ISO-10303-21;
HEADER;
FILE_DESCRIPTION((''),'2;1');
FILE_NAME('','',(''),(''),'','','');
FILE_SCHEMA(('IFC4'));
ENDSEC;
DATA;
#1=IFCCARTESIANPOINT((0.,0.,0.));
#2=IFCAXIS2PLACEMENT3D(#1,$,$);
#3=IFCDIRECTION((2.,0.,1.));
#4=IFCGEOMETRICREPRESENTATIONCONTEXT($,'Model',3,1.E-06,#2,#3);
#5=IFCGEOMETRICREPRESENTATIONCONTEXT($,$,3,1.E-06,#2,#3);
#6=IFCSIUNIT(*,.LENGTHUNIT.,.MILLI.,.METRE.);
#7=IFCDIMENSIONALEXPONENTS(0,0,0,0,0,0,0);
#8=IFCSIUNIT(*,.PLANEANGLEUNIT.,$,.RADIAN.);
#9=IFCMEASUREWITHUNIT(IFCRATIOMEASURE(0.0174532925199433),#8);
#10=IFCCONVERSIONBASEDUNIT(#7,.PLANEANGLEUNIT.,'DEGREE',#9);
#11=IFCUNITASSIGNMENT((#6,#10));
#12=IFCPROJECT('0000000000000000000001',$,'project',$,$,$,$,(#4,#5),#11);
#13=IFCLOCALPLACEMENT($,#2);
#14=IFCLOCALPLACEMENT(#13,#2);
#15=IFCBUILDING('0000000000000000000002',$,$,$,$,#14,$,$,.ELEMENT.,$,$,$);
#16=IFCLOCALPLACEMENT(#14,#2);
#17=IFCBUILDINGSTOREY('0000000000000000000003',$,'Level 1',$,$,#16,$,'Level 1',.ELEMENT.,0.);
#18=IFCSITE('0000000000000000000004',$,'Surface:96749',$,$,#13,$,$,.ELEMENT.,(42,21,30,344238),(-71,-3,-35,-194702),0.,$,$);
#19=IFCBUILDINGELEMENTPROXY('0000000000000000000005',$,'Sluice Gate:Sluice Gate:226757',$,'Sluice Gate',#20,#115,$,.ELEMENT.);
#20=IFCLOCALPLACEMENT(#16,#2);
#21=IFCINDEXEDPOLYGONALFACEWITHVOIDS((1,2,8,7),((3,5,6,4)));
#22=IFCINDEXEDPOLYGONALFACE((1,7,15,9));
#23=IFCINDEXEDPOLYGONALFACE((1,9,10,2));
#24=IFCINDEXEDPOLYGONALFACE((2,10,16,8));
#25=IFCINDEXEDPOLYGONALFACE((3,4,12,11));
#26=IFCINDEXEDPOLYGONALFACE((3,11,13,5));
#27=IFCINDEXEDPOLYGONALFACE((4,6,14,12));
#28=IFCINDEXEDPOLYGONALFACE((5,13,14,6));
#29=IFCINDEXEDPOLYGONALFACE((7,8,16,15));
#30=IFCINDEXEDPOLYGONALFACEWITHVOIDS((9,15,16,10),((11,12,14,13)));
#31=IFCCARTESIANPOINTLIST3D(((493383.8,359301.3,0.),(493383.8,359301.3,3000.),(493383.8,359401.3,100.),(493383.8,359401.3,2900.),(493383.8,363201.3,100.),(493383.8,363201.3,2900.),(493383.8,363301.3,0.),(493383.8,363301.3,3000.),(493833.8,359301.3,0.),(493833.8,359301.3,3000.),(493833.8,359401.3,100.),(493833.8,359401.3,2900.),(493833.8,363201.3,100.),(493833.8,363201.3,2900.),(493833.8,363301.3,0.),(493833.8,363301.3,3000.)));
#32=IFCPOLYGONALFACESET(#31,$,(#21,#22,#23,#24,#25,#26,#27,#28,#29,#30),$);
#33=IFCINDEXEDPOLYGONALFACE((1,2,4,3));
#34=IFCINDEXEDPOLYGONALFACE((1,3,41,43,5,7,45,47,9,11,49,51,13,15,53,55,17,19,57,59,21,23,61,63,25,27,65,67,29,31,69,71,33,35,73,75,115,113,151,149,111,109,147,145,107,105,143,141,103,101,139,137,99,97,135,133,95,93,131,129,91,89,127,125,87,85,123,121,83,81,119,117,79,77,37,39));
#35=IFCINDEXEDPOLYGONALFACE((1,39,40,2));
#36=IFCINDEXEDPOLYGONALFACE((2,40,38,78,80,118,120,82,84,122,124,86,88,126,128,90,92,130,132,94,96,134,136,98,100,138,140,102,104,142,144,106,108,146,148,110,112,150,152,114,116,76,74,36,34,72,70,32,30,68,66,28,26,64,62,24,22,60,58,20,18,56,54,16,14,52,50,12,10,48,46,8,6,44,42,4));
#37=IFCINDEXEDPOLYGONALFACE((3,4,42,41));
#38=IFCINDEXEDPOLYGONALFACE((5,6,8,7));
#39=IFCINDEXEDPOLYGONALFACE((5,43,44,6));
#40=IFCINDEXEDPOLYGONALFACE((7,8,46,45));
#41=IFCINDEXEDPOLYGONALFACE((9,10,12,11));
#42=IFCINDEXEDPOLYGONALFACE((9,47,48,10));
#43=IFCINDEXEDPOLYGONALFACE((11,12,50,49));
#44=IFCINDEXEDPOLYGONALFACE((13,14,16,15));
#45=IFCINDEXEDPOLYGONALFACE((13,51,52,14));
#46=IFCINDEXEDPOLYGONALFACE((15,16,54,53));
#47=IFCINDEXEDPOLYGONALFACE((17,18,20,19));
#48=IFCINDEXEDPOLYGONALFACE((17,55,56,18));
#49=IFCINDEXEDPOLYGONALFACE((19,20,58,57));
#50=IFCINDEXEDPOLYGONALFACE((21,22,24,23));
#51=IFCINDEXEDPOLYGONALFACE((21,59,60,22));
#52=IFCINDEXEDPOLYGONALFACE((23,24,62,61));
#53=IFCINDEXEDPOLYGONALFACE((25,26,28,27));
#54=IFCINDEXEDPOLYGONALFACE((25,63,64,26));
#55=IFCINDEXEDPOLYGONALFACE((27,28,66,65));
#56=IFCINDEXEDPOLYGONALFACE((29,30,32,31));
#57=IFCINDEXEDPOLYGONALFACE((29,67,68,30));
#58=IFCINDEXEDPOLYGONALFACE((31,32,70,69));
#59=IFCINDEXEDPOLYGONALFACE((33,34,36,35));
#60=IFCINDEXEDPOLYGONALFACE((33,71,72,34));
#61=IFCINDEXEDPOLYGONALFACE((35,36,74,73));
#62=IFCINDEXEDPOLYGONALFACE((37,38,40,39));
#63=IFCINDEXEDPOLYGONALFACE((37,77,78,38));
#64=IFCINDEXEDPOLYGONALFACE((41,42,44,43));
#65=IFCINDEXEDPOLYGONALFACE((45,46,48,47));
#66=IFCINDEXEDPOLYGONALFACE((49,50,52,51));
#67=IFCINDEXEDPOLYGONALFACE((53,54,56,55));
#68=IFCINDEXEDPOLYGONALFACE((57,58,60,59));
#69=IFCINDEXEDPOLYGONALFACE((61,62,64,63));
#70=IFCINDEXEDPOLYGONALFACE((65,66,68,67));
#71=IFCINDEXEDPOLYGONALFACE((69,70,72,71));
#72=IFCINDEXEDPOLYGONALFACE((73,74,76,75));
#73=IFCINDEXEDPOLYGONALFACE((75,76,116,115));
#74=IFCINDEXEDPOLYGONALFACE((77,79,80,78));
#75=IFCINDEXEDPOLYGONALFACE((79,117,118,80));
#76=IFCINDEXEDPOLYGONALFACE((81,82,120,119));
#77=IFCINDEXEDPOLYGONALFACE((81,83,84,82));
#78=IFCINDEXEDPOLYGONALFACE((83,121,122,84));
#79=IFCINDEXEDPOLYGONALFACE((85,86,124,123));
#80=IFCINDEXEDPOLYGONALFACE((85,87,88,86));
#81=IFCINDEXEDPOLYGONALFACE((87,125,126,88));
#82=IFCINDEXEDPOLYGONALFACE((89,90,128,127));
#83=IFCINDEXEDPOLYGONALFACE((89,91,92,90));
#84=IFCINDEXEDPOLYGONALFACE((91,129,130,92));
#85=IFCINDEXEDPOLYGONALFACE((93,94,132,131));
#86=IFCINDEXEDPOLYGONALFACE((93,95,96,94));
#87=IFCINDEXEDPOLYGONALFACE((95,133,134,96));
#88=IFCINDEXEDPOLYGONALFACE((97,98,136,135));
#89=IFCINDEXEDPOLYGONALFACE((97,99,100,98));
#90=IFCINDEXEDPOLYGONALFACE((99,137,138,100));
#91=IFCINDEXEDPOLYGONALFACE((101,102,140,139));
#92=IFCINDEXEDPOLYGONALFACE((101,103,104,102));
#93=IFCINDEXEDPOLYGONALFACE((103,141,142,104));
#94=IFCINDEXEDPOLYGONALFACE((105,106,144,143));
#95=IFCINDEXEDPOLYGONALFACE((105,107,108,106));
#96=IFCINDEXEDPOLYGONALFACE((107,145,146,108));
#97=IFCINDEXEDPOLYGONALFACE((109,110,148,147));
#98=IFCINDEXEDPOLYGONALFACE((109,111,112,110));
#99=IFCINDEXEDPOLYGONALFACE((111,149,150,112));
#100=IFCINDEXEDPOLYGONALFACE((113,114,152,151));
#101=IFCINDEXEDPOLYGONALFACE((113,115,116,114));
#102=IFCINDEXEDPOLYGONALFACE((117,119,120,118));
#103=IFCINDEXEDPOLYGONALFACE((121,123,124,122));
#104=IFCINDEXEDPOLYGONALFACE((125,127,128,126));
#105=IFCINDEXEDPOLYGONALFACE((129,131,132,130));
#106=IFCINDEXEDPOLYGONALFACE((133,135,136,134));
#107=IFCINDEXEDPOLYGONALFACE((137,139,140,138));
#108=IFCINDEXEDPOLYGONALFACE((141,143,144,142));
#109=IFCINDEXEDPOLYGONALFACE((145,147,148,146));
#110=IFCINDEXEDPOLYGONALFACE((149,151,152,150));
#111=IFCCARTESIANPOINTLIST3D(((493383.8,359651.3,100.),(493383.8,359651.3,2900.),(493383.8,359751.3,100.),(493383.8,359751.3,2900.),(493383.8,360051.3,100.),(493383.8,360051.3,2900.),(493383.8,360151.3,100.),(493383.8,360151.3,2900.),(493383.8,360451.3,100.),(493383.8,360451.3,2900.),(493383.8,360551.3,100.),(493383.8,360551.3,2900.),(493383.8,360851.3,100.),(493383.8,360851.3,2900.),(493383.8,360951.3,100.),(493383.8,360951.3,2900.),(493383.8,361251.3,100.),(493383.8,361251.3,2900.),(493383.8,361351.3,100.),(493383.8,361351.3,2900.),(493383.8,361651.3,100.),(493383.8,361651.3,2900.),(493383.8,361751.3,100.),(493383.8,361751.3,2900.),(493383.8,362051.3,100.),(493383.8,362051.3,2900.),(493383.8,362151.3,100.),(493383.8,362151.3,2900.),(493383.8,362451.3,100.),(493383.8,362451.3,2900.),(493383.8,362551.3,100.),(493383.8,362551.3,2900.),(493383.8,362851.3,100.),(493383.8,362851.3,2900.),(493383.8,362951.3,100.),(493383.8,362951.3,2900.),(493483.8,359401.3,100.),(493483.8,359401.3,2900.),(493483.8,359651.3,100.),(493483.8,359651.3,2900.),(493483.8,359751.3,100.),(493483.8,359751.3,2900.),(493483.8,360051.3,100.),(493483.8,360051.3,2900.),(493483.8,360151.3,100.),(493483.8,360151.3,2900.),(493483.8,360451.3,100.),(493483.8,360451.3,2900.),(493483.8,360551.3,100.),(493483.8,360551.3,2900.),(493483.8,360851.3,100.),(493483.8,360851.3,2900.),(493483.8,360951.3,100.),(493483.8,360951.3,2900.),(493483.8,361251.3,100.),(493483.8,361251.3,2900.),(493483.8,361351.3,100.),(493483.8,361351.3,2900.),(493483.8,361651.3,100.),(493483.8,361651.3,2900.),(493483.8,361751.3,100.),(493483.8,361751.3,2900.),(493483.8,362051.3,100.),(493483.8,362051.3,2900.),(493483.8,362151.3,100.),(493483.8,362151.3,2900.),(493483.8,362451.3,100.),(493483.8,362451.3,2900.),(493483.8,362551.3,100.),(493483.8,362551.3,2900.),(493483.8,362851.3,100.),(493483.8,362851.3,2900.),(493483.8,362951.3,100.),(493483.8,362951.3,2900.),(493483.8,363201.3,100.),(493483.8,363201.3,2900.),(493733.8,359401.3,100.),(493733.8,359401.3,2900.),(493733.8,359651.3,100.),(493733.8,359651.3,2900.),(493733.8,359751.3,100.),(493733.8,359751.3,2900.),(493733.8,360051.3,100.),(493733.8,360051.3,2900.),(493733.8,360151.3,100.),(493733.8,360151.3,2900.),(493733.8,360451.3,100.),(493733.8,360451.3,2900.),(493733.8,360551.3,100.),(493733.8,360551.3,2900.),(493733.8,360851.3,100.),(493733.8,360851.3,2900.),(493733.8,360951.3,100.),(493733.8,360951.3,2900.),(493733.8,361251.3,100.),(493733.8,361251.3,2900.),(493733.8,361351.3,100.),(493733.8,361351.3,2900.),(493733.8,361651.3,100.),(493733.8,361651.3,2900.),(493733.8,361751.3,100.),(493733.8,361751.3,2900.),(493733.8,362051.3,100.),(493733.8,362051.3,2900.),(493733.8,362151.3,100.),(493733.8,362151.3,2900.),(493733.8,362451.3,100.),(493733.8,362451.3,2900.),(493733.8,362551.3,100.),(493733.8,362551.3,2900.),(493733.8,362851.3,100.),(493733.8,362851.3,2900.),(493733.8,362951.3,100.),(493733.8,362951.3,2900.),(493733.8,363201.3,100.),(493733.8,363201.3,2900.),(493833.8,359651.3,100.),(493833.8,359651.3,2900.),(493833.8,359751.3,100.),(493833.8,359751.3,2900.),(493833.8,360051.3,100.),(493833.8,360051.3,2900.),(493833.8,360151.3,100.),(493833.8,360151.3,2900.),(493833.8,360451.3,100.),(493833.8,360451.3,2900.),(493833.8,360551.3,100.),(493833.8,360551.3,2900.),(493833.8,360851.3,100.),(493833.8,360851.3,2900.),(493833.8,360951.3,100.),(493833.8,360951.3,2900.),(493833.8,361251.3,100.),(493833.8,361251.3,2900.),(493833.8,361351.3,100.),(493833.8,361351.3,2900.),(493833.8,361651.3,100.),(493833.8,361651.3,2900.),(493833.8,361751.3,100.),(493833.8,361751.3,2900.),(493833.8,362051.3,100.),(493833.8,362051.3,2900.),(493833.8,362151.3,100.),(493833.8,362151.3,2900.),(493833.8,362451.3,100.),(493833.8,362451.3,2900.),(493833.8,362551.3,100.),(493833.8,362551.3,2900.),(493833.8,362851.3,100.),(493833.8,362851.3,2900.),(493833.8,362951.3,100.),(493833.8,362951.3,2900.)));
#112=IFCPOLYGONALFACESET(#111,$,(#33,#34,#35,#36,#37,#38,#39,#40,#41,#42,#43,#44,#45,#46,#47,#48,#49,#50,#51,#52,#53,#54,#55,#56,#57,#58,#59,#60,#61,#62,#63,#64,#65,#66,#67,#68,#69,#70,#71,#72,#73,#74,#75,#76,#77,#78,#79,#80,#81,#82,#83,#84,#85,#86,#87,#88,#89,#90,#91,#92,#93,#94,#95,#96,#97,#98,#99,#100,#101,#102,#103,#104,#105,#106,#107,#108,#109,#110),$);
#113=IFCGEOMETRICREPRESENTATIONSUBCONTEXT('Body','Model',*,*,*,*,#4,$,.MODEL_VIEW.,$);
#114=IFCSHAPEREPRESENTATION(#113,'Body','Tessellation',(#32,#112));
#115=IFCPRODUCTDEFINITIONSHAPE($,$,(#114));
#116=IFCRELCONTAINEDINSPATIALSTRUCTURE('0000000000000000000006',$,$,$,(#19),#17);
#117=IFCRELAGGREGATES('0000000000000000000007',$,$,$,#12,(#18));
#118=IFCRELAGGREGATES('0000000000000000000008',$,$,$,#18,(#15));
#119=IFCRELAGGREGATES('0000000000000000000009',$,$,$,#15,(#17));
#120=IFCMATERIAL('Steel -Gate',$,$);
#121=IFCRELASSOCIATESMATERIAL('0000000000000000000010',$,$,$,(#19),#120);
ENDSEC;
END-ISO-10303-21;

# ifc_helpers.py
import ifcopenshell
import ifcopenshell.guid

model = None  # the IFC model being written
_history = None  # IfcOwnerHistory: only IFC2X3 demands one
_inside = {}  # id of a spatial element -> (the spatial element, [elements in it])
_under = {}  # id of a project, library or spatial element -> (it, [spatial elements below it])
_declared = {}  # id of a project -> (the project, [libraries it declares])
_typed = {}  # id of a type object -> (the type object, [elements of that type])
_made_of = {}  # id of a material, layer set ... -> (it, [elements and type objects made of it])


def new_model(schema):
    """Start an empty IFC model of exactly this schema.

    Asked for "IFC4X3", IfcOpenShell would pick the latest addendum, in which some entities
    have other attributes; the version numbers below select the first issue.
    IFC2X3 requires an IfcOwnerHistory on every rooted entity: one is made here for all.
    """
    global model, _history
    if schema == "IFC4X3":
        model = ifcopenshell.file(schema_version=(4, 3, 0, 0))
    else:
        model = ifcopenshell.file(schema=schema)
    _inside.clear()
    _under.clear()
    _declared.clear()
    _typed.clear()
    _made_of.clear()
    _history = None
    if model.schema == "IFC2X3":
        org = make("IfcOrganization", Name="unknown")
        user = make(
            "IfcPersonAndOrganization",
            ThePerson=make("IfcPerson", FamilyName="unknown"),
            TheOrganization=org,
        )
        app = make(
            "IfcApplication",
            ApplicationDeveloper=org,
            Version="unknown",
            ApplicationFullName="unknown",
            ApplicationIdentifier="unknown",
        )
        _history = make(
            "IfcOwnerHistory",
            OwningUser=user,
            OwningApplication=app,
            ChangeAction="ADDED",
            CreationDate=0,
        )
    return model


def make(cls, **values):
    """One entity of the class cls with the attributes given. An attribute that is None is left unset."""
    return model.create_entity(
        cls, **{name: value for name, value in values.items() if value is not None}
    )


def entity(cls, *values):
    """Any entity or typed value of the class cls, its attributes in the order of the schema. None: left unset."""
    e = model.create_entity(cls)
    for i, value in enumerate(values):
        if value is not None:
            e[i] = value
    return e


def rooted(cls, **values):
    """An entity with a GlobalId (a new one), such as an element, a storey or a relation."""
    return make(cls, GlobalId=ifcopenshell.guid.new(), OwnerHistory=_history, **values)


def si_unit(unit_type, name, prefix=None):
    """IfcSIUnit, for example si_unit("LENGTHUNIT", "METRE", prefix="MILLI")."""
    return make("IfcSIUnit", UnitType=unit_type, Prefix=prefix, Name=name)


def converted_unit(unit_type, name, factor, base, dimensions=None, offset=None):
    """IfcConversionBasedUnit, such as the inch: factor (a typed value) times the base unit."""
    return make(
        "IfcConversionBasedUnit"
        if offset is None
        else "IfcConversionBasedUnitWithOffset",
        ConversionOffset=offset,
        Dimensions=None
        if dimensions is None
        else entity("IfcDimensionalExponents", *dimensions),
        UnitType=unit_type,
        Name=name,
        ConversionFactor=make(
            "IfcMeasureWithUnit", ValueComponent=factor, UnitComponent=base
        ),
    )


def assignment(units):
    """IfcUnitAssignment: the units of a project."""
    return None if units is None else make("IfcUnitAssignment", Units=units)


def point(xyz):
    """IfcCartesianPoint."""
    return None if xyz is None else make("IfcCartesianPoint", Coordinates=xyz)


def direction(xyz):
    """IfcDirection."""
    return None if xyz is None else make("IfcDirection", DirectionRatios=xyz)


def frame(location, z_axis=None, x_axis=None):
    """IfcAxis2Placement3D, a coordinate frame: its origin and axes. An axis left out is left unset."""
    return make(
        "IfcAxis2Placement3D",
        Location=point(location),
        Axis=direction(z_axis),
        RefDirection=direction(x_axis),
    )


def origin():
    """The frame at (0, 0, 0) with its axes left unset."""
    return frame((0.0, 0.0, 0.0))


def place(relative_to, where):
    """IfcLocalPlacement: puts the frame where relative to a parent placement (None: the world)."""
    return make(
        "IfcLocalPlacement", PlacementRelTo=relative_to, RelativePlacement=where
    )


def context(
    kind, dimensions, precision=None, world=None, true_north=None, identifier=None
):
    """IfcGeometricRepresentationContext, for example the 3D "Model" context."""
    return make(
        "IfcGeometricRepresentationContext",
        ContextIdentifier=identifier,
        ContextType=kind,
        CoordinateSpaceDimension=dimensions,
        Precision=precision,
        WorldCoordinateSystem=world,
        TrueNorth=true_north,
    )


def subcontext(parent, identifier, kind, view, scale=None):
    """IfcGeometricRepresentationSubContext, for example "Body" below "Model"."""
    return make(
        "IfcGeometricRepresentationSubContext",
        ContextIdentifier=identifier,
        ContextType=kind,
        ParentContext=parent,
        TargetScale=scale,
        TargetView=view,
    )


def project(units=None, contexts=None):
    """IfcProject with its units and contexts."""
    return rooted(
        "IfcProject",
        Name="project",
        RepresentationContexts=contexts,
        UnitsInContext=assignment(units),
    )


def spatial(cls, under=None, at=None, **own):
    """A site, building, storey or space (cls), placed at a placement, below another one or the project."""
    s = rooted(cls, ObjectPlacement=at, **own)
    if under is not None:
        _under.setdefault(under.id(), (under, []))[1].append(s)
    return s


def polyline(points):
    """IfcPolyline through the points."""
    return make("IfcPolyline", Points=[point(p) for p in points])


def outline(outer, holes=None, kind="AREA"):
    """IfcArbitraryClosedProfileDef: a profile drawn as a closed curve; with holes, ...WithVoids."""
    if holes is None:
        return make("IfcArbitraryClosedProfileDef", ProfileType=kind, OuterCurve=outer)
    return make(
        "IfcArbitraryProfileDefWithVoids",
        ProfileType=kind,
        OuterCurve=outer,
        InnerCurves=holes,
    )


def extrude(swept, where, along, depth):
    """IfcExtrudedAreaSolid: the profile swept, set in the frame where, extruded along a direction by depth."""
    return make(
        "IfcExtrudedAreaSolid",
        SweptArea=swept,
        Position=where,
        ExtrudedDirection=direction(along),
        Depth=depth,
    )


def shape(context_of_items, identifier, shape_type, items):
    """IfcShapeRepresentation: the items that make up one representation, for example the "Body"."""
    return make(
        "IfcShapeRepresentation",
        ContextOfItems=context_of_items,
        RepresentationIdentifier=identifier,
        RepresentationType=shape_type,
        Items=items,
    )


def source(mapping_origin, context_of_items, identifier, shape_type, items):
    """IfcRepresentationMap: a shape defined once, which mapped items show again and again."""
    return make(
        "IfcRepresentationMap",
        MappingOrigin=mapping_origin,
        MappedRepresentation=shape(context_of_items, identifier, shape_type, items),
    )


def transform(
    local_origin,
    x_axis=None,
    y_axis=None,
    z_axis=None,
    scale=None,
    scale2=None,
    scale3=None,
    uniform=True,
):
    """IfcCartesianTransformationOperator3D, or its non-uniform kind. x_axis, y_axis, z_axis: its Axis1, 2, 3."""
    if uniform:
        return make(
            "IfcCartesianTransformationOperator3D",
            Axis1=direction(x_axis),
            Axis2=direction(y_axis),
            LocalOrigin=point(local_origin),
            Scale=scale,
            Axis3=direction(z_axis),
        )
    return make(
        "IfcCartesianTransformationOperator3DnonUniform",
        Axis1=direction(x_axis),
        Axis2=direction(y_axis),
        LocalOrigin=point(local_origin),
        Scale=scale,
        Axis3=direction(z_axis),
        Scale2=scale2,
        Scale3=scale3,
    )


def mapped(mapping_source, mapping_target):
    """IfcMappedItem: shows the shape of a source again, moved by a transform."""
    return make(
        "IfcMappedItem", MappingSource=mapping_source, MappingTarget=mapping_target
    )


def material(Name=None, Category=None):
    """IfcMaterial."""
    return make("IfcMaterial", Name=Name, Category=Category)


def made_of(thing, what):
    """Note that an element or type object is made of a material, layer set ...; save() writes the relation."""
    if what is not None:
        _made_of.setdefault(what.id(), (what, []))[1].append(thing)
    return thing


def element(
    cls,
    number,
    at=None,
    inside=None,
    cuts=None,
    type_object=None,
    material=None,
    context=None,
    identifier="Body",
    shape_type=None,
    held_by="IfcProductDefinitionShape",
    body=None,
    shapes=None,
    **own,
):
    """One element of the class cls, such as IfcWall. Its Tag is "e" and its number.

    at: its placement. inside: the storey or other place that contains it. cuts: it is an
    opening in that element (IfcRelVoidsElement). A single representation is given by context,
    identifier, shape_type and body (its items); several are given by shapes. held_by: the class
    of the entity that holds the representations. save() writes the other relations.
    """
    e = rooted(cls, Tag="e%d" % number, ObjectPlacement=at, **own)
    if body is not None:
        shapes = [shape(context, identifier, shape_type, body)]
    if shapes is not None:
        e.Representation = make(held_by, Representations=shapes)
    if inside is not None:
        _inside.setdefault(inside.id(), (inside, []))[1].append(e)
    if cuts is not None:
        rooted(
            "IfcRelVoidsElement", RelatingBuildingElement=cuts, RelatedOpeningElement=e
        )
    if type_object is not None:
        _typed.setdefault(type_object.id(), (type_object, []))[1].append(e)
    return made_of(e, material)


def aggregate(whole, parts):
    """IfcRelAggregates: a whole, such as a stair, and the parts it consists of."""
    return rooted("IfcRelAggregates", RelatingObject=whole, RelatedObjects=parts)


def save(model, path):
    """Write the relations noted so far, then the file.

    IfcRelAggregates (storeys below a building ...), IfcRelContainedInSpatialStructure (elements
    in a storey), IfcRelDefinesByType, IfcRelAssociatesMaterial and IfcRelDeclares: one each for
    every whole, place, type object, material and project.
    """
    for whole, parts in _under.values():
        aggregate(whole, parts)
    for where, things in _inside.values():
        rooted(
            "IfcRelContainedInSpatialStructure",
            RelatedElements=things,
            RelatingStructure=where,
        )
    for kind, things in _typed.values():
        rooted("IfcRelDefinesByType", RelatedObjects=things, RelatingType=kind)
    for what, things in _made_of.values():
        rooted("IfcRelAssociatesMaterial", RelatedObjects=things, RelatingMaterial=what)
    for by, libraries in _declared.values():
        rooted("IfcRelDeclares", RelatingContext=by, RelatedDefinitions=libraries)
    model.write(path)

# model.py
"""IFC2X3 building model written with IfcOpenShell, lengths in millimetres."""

from ifc_helpers import new_model, entity, si_unit, converted_unit, direction, frame, origin, place, context, subcontext, project, spatial, polyline, outline, extrude, source, transform, mapped, material, element, save


model = new_model("IFC2X3")

# Units and contexts
model_context = context("Model", 3, precision=1e-06, world=origin(), true_north=direction((2.0, 0.0, 1.0)))
context_of_model = context(None, 3, precision=1e-06, world=origin(), true_north=direction((2.0, 0.0, 1.0)))
body_context = subcontext(model_context, "Body", "Model", "MODEL_VIEW")
ifc_project = project(units=[si_unit("LENGTHUNIT", "METRE", prefix="MILLI"), converted_unit("PLANEANGLEUNIT", "DEGREE", entity("IfcRatioMeasure", 0.0174532925199433), si_unit("PLANEANGLEUNIT", "RADIAN"), dimensions=[0, 0, 0, 0, 0, 0, 0])], contexts=[model_context, context_of_model])

# Site, building, storey
site_placement = place(None, origin())
site = spatial("IfcSite", under=ifc_project, at=site_placement, Name="Surface:96749", CompositionType="ELEMENT", RefLatitude=(42, 21, 30, 344238), RefLongitude=(-71, -3, -35, -194702), RefElevation=0.0)
building_placement = place(site_placement, origin())
building = spatial("IfcBuilding", under=site, at=building_placement, CompositionType="ELEMENT")
storey_placement = place(building_placement, origin())
storey = spatial("IfcBuildingStorey", under=building, at=storey_placement, Name="Level 1", LongName="Level 1", CompositionType="ELEMENT", Elevation=0.0)

# Building element proxy
ifc_material = material(Name="Steel -Gate")
shared_shape_1 = source(origin(), body_context, "Body", "SweptSolid", [
    extrude(outline(polyline([(-2000.0, -1500.0), (2000.0, -1500.0), (2000.0, 1500.0), (-2000.0, 1500.0), (-2000.0, -1500.0)]), holes=[polyline([(-1900.0, 1400.0), (1900.0, 1400.0), (1900.0, -1400.0), (-1900.0, -1400.0), (-1900.0, 1400.0)])]), frame((0.0, -225.0, 1500.0), z_axis=(0.0, 1.0, 0.0), x_axis=(-1.0, 0.0, 0.0)), (0.0, 0.0, 1.0), 450.0),
    extrude(outline(polyline([(125.0, -1650.0), (225.0, -1650.0), (225.0, -1550.0), (125.0, -1550.0), (125.0, -1250.0), (225.0, -1250.0), (225.0, -1150.0), (125.0, -1150.0), (125.0, -850.0), (225.0, -850.0), (225.0, -750.0), (125.0, -750.0), (125.0, -450.0), (225.0, -450.0), (225.0, -350.0), (125.0, -350.0), (125.0, -50.0), (225.0, -50.0), (225.0, 50.0), (125.0, 50.0), (125.0, 350.0), (225.0, 350.0), (225.0, 450.0), (125.0, 450.0), (125.0, 750.0), (225.0, 750.0), (225.0, 850.0), (125.0, 850.0), (125.0, 1150.0), (225.0, 1150.0), (225.0, 1250.0), (125.0, 1250.0), (125.0, 1550.0), (225.0, 1550.0), (225.0, 1650.0), (125.0, 1650.0), (125.0, 1900.0), (-125.0, 1900.0), (-125.0, 1650.0), (-225.0, 1650.0), (-225.0, 1550.0), (-125.0, 1550.0), (-125.0, 1250.0), (-225.0, 1250.0), (-225.0, 1150.0), (-125.0, 1150.0), (-125.0, 850.0), (-225.0, 850.0), (-225.0, 750.0), (-125.0, 750.0), (-125.0, 450.0), (-225.0, 450.0), (-225.0, 350.0), (-125.0, 350.0), (-125.0, 50.0), (-225.0, 50.0), (-225.0, -50.0), (-125.0, -50.0), (-125.0, -350.0), (-225.0, -350.0), (-225.0, -450.0), (-125.0, -450.0), (-125.0, -750.0), (-225.0, -750.0), (-225.0, -850.0), (-125.0, -850.0), (-125.0, -1150.0), (-225.0, -1150.0), (-225.0, -1250.0), (-125.0, -1250.0), (-125.0, -1550.0), (-225.0, -1550.0), (-225.0, -1650.0), (-125.0, -1650.0), (-125.0, -1900.0), (125.0, -1900.0), (125.0, -1650.0)])), frame((0.0, 0.0, 100.0), z_axis=(0.0, 0.0, 1.0), x_axis=(0.0, -1.0, 0.0)), (0.0, 0.0, 1.0), 2800.0),
])
for number, where, z_axis, x_axis, name in (
    (1, (493608.8, 361301.3, 0.0), (0.0, 0.0, 1.0), (0.0, 1.0, 0.0), "Sluice Gate:Sluice Gate:226757"),
):
    element("IfcBuildingElementProxy", number, at=place(storey_placement, frame(where, z_axis=z_axis, x_axis=x_axis)), inside=storey, material=ifc_material, Name=name, ObjectType="Sluice Gate", CompositionType="ELEMENT", context=body_context, shape_type="MappedRepresentation", body=[
        mapped(shared_shape_1, transform((0.0, 0.0, 0.0), scale=1.0)),
    ])

save(model, "model.ifc")
